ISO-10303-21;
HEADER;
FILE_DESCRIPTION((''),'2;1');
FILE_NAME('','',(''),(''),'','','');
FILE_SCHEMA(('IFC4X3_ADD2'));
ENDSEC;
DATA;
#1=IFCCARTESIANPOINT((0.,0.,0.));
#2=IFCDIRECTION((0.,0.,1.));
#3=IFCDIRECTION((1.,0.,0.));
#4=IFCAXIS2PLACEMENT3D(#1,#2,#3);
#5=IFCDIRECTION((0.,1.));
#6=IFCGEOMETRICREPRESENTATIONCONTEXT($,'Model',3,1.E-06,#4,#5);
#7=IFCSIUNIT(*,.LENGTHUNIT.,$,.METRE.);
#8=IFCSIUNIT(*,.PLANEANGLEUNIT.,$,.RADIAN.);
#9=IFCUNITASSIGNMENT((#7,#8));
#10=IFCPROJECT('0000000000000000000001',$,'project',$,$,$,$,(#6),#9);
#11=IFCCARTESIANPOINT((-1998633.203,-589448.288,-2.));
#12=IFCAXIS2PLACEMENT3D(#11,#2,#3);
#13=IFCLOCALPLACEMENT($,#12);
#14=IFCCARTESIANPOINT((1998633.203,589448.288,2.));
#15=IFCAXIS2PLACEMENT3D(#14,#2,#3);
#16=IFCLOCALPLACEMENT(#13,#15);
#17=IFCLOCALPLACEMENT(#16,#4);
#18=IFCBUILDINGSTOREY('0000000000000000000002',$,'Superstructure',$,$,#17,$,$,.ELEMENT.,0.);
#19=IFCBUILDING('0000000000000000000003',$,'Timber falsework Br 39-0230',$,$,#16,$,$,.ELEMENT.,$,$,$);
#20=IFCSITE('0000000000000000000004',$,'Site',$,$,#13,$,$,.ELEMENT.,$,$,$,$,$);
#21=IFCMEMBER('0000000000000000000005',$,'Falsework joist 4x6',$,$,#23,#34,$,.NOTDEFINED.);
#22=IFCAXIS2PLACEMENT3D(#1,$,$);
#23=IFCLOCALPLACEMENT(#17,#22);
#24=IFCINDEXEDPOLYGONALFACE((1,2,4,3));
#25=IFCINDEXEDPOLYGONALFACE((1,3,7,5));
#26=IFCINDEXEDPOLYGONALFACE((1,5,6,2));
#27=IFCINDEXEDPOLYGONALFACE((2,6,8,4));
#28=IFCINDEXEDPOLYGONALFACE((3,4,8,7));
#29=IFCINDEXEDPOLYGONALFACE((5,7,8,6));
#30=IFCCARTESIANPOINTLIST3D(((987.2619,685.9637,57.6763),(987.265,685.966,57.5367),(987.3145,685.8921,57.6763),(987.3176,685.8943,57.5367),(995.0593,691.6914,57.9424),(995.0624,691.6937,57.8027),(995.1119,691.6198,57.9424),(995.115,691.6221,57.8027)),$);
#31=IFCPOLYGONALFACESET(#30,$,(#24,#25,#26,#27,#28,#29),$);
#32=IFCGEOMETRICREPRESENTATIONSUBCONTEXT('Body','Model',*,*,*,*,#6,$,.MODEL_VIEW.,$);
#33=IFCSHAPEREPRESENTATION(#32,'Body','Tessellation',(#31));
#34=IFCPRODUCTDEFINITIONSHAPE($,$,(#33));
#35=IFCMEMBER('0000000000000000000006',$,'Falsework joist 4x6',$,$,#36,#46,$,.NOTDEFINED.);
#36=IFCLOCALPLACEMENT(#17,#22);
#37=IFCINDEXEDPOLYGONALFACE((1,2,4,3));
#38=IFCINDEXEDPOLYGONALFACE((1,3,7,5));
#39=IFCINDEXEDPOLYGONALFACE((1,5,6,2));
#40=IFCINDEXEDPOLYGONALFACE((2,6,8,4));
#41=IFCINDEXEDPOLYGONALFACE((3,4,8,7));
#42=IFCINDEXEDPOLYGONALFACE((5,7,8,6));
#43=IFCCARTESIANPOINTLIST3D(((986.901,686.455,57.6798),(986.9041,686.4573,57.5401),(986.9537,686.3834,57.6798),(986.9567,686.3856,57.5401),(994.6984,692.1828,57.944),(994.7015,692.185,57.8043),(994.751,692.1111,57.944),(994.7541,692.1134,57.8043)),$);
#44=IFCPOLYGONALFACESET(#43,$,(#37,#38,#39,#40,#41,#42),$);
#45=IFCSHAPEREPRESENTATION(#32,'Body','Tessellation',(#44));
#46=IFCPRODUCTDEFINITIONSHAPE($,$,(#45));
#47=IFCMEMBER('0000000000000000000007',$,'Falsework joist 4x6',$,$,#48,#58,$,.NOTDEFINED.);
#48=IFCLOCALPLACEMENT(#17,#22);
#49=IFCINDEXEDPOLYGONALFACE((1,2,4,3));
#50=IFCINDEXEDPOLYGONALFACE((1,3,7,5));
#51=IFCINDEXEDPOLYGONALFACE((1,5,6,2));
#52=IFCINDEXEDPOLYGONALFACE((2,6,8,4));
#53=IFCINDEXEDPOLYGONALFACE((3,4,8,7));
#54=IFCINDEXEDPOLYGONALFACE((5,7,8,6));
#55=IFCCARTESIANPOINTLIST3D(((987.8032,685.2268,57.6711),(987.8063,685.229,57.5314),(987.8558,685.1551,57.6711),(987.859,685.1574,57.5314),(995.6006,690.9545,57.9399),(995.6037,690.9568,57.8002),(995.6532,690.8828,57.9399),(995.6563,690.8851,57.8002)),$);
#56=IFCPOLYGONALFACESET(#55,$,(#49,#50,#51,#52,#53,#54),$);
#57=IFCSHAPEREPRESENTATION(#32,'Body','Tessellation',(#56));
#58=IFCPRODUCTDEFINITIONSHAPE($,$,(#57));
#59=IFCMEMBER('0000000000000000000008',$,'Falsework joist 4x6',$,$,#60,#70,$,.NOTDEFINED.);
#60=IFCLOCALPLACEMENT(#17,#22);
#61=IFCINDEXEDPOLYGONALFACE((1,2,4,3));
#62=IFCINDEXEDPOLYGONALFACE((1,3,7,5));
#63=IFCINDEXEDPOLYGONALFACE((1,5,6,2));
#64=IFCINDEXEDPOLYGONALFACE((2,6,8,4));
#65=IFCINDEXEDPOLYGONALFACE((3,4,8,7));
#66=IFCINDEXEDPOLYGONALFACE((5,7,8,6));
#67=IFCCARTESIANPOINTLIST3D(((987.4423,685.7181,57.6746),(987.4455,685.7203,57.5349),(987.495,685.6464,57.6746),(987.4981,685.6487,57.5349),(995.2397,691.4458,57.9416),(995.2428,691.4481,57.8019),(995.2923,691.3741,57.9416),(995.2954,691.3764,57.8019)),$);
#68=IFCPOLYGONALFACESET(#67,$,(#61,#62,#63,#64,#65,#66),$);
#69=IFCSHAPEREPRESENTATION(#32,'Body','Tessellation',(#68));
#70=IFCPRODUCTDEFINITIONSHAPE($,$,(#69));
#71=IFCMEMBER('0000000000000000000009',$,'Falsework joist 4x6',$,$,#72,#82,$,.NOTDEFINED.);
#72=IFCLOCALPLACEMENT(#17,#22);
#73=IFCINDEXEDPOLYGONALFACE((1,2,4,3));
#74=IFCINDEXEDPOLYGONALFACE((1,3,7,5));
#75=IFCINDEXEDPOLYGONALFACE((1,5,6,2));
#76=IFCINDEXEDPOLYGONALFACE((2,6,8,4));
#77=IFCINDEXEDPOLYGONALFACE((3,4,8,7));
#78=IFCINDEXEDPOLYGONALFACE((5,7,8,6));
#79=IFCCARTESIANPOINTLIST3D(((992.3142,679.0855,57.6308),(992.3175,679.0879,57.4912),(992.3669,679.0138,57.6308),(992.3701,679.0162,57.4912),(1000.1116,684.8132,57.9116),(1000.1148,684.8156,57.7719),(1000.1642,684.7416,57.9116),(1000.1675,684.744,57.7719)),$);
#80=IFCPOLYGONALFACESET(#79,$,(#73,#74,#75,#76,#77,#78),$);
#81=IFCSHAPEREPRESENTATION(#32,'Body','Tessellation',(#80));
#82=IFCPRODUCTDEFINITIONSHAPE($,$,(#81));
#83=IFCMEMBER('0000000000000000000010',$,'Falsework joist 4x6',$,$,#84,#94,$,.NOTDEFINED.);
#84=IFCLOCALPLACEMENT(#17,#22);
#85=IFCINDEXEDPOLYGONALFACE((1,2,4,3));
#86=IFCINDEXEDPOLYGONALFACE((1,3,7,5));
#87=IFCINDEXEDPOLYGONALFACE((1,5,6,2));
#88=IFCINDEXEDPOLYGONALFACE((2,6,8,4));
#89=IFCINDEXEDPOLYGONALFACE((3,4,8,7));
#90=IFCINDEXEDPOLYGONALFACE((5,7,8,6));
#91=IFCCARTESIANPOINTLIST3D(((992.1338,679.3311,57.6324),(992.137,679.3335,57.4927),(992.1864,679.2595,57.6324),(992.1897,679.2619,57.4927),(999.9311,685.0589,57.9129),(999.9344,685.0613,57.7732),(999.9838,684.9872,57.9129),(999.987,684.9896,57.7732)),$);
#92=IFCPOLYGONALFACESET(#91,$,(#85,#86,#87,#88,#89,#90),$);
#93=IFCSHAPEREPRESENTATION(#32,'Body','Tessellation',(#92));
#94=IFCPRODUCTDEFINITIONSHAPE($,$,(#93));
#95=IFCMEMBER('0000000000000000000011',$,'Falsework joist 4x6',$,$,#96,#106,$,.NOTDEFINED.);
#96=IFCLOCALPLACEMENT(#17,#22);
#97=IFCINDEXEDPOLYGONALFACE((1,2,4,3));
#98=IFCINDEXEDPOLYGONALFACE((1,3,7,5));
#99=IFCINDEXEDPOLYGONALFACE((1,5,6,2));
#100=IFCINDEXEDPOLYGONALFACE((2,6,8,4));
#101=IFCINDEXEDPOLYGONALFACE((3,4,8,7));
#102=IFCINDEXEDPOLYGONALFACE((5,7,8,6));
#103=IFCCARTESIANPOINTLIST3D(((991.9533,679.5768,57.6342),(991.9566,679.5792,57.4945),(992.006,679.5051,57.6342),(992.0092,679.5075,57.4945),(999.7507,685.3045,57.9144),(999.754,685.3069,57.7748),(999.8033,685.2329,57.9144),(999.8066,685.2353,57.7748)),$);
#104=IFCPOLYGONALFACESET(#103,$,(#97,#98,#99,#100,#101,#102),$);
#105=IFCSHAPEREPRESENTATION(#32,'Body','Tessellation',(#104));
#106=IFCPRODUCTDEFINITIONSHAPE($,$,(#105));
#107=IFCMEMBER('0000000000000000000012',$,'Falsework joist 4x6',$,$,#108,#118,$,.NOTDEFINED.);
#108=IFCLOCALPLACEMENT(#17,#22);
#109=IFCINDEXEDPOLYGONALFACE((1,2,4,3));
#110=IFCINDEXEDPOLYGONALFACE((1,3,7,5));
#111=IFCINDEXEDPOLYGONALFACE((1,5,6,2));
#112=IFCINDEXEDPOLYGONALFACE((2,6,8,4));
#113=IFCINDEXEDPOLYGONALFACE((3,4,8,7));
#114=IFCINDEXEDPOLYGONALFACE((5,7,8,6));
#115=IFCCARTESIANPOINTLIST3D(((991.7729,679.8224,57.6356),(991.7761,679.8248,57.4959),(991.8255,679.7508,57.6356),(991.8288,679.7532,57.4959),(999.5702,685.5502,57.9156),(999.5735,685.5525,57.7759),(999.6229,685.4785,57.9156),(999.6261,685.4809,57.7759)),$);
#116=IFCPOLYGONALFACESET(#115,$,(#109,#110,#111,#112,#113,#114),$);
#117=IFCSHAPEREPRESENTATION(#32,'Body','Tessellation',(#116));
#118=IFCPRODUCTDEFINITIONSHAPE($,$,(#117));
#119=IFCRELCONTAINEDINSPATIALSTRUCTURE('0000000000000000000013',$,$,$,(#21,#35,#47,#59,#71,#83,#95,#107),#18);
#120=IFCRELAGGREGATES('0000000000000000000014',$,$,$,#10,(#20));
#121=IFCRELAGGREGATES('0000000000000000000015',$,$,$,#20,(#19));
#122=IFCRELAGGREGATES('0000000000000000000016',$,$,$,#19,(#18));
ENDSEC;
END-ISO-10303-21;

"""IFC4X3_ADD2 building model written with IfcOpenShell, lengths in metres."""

from ifc_helpers import new_model, si_unit, direction, frame, frame_2d, origin, origin_with_axes, place, context, subcontext, project, spatial, rectangle, extrude, element, save


model = new_model("IFC4X3_ADD2")

# Units and contexts
model_context = context("Model", 3, precision=1e-06, world=origin_with_axes(), true_north=direction((0.0, 1.0)))
body_context = subcontext(model_context, "Body", "Model", "MODEL_VIEW")
ifc_project = project(units=[si_unit("LENGTHUNIT", "METRE"), si_unit("PLANEANGLEUNIT", "RADIAN")], contexts=[model_context])

# Site, building, storey
site_placement = place(None, frame((-1998633.203, -589448.288, -2.0), z_axis=(0.0, 0.0, 1.0), x_axis=(1.0, 0.0, 0.0)))
site = spatial("IfcSite", under=ifc_project, at=site_placement, Name="Site", CompositionType="ELEMENT")
building_placement = place(site_placement, frame((1998633.203, 589448.288, 2.0), z_axis=(0.0, 0.0, 1.0), x_axis=(1.0, 0.0, 0.0)))
building = spatial("IfcBuilding", under=site, at=building_placement, Name="Timber falsework Br 39-0230", CompositionType="ELEMENT")
storey_placement = place(building_placement, origin_with_axes())
storey = spatial("IfcBuildingStorey", under=building, at=storey_placement, Name="Superstructure", CompositionType="ELEMENT", Elevation=0.0)

# Members
member_1_placement = place(storey_placement, frame((987.2913, 685.9302, 57.5367), z_axis=(0.805624, 0.591789, 0.02749), x_axis=(-0.592013, 0.805928, 0.0)))
element("IfcMember", 1, at=member_1_placement, inside=storey, Name="Falsework joist 4x6", PredefinedType="NOTDEFINED", context=body_context, shape_type="SweptSolid", body=[
    extrude(rectangle(XDim=0.0889, YDim=0.1397, at=frame_2d((0.0, 0.0698))), origin(), (0.0, 0.0, 1.0), 9.6787),
])
member_2_placement = place(storey_placement, frame((986.9304, 686.4215, 57.5401), z_axis=(0.805628, 0.591793, 0.0273), x_axis=(-0.592013, 0.805928, 0.0)))
element("IfcMember", 2, at=member_2_placement, inside=storey, Name="Falsework joist 4x6", PredefinedType="NOTDEFINED", context=body_context, shape_type="SweptSolid", body=[
    extrude(rectangle(XDim=0.0889, YDim=0.1397, at=frame_2d((0.0, 0.0698))), origin(), (0.0, 0.0, 1.0), 9.6786),
])
member_3_placement = place(storey_placement, frame((987.8327, 685.1932, 57.5314), z_axis=(0.805617, 0.591785, 0.027773), x_axis=(-0.592013, 0.805928, 0.0)))
element("IfcMember", 3, at=member_3_placement, inside=storey, Name="Falsework joist 4x6", PredefinedType="NOTDEFINED", context=body_context, shape_type="SweptSolid", body=[
    extrude(rectangle(XDim=0.0889, YDim=0.1397, at=frame_2d((0.0, 0.0698))), origin(), (0.0, 0.0, 1.0), 9.6787),
])
member_4_placement = place(storey_placement, frame((987.4718, 685.6845, 57.5349), z_axis=(0.805622, 0.591788, 0.027584), x_axis=(-0.592013, 0.805928, 0.0)))
element("IfcMember", 4, at=member_4_placement, inside=storey, Name="Falsework joist 4x6", PredefinedType="NOTDEFINED", context=body_context, shape_type="SweptSolid", body=[
    extrude(rectangle(XDim=0.0889, YDim=0.1397, at=frame_2d((0.0, 0.0698))), origin(), (0.0, 0.0, 1.0), 9.6787),
])
member_5_placement = place(storey_placement, frame((992.3438, 679.0521, 57.4912), z_axis=(0.805589, 0.591764, 0.029004), x_axis=(-0.592013, 0.805928, 0.0)))
element("IfcMember", 5, at=member_5_placement, inside=storey, Name="Falsework joist 4x6", PredefinedType="NOTDEFINED", context=body_context, shape_type="SweptSolid", body=[
    extrude(rectangle(XDim=0.0889, YDim=0.1397, at=frame_2d((0.0, 0.0698))), origin(), (0.0, 0.0, 1.0), 9.6791),
])
member_6_placement = place(storey_placement, frame((992.1634, 679.2977, 57.4927), z_axis=(0.80559, 0.591765, 0.028979), x_axis=(-0.592013, 0.805928, 0.0)))
element("IfcMember", 6, at=member_6_placement, inside=storey, Name="Falsework joist 4x6", PredefinedType="NOTDEFINED", context=body_context, shape_type="SweptSolid", body=[
    extrude(rectangle(XDim=0.0889, YDim=0.1397, at=frame_2d((0.0, 0.0698))), origin(), (0.0, 0.0, 1.0), 9.6791),
])
member_7_placement = place(storey_placement, frame((991.9829, 679.5433, 57.4945), z_axis=(0.80559, 0.591765, 0.028954), x_axis=(-0.592013, 0.805928, 0.0)))
element("IfcMember", 7, at=member_7_placement, inside=storey, Name="Falsework joist 4x6", PredefinedType="NOTDEFINED", context=body_context, shape_type="SweptSolid", body=[
    extrude(rectangle(XDim=0.0889, YDim=0.1397, at=frame_2d((0.0, 0.0698))), origin(), (0.0, 0.0, 1.0), 9.6791),
])
member_8_placement = place(storey_placement, frame((991.8025, 679.789, 57.4959), z_axis=(0.805591, 0.591765, 0.028928), x_axis=(-0.592013, 0.805928, 0.0)))
element("IfcMember", 8, at=member_8_placement, inside=storey, Name="Falsework joist 4x6", PredefinedType="NOTDEFINED", context=body_context, shape_type="SweptSolid", body=[
    extrude(rectangle(XDim=0.0889, YDim=0.1397, at=frame_2d((0.0, 0.0698))), origin(), (0.0, 0.0, 1.0), 9.6791),
])

save(model, "model.ifc")
